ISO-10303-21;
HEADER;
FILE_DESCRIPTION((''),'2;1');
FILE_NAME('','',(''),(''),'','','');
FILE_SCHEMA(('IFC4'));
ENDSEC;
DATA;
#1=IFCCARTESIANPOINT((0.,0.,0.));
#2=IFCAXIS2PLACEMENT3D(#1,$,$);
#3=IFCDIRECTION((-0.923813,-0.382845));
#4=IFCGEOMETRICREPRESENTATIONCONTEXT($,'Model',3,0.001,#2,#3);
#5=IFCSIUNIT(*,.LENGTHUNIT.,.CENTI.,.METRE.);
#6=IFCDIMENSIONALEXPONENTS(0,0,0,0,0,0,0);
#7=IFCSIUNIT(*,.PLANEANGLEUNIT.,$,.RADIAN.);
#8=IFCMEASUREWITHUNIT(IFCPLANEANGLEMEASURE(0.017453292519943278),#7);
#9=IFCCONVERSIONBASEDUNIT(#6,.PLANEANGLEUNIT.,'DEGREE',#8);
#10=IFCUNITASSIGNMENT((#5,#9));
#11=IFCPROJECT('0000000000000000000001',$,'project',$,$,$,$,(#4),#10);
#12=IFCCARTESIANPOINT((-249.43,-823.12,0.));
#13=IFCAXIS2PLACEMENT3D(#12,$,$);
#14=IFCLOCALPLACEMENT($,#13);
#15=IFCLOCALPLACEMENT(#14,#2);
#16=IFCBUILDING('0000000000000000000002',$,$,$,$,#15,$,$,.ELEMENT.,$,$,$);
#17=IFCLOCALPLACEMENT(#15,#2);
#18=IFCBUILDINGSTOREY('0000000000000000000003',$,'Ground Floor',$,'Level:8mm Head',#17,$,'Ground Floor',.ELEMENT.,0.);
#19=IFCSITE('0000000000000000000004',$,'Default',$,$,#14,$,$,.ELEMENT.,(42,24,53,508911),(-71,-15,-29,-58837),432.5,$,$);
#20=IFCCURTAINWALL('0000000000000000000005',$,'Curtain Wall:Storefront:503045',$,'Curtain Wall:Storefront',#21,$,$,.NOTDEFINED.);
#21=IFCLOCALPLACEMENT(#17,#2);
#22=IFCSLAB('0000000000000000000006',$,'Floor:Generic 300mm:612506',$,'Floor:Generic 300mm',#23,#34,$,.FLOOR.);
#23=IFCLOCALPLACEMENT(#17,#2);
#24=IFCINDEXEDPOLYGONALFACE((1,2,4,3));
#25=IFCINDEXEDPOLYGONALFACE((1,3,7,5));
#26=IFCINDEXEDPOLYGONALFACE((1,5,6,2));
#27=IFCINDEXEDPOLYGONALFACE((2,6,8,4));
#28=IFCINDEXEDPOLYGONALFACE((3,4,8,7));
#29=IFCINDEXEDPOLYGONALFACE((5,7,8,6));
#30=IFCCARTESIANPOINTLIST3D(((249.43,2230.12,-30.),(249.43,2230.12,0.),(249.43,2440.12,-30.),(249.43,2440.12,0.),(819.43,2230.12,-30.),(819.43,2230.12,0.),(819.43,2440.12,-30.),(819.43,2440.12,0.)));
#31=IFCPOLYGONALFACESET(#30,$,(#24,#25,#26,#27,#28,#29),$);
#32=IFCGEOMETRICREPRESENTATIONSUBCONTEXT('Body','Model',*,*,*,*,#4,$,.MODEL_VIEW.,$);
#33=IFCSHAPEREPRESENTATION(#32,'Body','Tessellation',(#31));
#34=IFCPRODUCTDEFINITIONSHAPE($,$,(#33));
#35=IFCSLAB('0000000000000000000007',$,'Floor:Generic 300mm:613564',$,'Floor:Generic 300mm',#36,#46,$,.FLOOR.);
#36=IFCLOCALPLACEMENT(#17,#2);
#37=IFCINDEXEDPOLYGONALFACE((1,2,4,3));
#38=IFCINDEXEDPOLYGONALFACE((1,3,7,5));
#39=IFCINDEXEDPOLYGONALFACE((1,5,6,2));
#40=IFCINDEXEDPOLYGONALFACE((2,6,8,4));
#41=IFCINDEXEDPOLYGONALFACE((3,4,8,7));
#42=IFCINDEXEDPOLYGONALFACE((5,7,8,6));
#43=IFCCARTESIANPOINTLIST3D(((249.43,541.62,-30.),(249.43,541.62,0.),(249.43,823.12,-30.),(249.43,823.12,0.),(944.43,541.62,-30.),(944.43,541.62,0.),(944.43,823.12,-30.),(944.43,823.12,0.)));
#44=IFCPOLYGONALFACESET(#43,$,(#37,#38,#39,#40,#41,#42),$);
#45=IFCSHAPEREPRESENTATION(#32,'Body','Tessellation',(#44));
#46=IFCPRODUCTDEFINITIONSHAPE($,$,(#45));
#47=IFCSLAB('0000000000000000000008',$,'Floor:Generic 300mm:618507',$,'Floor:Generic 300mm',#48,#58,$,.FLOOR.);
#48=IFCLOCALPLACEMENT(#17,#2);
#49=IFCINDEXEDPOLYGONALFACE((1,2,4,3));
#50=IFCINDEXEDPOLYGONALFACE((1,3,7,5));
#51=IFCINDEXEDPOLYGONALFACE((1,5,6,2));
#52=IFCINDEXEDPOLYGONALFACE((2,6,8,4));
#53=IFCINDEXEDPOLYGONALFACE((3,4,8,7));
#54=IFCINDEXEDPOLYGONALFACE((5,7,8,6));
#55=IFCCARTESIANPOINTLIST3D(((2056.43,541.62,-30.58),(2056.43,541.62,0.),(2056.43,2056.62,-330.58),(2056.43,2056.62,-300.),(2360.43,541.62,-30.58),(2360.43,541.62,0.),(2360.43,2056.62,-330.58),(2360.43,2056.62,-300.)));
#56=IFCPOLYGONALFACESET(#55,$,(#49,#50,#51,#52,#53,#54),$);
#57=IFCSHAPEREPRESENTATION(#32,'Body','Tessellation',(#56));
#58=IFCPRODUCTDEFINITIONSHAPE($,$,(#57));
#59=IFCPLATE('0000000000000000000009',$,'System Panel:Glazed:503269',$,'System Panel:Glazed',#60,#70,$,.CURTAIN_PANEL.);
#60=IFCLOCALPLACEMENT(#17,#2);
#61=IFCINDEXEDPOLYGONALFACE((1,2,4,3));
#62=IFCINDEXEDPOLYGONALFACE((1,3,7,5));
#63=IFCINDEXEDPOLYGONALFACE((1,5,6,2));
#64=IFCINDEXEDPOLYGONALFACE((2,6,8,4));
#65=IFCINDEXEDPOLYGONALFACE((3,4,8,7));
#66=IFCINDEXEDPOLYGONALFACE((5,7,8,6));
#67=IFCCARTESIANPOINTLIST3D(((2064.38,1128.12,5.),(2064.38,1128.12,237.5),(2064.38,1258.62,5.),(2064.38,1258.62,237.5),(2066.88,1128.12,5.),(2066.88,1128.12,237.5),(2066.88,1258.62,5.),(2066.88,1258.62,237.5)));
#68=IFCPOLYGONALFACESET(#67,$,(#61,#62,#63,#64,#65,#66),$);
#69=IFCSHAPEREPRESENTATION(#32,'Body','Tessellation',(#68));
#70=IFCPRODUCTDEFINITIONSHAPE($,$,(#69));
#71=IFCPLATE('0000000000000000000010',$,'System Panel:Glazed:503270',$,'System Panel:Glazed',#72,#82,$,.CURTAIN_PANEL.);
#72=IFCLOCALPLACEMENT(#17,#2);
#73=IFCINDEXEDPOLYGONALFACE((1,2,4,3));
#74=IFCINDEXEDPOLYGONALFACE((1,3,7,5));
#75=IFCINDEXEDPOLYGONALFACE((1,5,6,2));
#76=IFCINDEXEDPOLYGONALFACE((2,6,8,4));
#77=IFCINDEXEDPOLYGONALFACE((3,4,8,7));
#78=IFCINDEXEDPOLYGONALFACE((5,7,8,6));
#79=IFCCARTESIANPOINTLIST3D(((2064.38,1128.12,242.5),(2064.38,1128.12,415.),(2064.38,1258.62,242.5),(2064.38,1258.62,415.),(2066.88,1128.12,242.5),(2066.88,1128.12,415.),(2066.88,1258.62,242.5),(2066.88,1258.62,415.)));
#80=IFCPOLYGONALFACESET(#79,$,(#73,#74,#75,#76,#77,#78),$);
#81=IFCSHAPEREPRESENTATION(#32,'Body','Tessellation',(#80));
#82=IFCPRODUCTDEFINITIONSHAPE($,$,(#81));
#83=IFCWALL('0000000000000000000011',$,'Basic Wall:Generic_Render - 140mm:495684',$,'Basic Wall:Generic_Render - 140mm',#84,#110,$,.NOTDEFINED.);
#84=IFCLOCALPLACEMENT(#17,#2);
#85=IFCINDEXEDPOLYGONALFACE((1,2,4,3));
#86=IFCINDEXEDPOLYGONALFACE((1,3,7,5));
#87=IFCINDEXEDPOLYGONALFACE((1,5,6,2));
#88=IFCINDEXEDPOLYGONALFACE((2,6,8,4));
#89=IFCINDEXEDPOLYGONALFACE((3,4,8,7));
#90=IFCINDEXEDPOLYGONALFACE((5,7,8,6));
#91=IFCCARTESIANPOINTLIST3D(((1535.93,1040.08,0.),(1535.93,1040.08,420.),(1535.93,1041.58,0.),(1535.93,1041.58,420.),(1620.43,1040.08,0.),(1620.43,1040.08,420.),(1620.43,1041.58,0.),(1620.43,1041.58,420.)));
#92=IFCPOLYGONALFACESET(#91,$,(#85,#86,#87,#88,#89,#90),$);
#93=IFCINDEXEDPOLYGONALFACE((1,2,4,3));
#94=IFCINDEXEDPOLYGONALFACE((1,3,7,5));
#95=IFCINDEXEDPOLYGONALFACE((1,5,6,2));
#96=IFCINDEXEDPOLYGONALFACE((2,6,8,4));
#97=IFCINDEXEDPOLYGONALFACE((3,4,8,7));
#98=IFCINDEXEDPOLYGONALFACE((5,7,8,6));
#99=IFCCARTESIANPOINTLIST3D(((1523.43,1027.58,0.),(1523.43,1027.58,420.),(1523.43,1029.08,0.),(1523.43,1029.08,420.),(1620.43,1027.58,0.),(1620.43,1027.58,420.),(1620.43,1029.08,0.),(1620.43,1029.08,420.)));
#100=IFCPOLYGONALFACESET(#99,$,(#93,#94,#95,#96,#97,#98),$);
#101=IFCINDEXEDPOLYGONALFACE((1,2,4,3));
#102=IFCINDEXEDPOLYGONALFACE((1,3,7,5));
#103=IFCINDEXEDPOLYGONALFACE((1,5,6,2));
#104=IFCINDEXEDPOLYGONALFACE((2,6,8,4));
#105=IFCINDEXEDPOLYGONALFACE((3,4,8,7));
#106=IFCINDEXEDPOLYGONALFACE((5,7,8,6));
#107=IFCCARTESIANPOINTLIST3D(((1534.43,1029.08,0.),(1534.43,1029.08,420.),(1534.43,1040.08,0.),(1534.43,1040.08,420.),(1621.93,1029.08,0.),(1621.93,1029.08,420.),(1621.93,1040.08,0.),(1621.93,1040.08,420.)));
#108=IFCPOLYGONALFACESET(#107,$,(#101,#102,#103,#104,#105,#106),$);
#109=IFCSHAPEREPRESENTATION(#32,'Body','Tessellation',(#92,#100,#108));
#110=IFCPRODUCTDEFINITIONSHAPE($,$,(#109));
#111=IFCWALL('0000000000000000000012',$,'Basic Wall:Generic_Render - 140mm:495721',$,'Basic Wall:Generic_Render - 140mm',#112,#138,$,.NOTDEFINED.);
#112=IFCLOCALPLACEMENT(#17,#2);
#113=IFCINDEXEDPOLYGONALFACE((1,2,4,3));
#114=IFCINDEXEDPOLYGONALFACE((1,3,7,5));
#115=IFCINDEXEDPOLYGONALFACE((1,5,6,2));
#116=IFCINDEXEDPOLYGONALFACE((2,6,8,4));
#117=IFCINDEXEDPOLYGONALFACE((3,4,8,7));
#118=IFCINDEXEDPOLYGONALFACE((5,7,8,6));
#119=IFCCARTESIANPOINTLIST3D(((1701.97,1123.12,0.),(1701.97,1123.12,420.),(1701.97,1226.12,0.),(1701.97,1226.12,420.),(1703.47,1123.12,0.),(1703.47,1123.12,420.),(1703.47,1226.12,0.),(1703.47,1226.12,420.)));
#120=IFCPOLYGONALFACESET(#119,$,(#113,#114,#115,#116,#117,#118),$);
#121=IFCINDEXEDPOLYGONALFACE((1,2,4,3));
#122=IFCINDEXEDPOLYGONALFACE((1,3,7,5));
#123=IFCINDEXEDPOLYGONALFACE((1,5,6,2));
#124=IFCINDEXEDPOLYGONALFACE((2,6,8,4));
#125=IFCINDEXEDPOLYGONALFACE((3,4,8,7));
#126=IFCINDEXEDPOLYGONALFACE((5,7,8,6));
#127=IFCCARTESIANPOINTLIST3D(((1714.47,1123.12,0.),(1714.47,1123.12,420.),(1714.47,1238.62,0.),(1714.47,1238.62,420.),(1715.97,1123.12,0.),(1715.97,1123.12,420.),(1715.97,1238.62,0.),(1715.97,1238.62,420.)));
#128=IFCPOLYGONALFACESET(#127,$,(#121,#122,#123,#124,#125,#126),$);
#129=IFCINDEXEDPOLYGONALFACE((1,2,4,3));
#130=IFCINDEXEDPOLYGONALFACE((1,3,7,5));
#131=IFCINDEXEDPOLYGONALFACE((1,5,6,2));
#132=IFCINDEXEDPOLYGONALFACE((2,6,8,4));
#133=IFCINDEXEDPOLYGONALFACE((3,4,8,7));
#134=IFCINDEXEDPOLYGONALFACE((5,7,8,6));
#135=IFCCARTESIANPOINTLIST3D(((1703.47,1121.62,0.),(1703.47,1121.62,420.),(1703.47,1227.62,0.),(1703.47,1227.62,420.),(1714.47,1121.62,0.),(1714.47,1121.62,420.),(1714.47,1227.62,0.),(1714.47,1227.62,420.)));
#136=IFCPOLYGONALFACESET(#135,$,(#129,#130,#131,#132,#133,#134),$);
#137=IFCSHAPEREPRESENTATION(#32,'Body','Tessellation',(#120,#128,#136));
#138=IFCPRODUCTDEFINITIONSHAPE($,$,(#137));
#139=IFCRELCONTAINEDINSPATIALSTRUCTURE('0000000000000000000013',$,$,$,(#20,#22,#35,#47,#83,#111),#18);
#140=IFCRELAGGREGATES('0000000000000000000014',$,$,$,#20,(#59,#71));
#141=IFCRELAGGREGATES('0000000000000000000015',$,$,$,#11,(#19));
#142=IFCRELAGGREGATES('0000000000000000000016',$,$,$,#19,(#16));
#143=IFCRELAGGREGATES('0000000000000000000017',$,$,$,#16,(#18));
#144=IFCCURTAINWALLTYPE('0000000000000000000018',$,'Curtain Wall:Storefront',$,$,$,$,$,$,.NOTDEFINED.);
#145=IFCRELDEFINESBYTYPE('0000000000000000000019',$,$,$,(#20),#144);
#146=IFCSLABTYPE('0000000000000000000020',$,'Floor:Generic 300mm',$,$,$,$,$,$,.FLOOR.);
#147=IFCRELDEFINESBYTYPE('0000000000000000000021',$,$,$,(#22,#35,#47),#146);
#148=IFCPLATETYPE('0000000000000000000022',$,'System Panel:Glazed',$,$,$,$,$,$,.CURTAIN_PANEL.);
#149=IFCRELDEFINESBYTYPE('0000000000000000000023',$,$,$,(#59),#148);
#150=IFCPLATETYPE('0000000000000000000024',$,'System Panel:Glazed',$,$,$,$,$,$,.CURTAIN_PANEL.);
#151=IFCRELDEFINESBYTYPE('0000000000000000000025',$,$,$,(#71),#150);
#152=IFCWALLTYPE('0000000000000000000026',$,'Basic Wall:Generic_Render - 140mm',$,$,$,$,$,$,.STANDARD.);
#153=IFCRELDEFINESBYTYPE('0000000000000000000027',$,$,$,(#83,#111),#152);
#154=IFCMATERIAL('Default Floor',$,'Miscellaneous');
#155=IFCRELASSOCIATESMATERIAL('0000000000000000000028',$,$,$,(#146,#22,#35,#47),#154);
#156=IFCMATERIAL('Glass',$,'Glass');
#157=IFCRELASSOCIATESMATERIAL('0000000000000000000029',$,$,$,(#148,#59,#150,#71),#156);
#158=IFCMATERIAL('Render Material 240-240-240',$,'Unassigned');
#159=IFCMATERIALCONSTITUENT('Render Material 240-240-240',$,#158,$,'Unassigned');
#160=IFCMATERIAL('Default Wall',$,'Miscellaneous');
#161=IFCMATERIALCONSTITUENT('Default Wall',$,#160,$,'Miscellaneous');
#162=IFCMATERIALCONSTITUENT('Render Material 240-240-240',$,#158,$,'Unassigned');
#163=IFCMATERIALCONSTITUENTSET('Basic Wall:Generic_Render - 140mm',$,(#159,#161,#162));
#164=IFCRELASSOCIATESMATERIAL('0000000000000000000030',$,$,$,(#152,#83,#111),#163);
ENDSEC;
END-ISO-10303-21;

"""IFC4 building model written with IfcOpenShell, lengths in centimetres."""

from ifc_helpers import new_model, entity, si_unit, converted_unit, direction, frame, frame_2d, origin, place, context, subcontext, project, spatial, indexed_curve, rectangle, outline, extrude, source, transform, mapped, material, constituent, constituent_set, type_object, type_shapes, element, aggregate, save


model = new_model("IFC4")

# Units and contexts
model_context = context("Model", 3, precision=0.001, world=origin(), true_north=direction((-0.923813, -0.382845)))
body_context = subcontext(model_context, "Body", "Model", "MODEL_VIEW")
ifc_project = project(units=[si_unit("LENGTHUNIT", "METRE", prefix="CENTI"), converted_unit("PLANEANGLEUNIT", "DEGREE", entity("IfcPlaneAngleMeasure", 0.017453292519943278), si_unit("PLANEANGLEUNIT", "RADIAN"), dimensions=[0, 0, 0, 0, 0, 0, 0])], contexts=[model_context])

# Site, building, storey
site_placement = place(None, frame((-249.43, -823.12, 0.0)))
site = spatial("IfcSite", under=ifc_project, at=site_placement, Name="Default", CompositionType="ELEMENT", RefLatitude=(42, 24, 53, 508911), RefLongitude=(-71, -15, -29, -58837), RefElevation=432.5)
building_placement = place(site_placement, origin())
building = spatial("IfcBuilding", under=site, at=building_placement, CompositionType="ELEMENT")
storey_placement = place(building_placement, origin())
storey = spatial("IfcBuildingStorey", under=building, at=storey_placement, Name="Ground Floor", ObjectType="Level:8mm Head", LongName="Ground Floor", CompositionType="ELEMENT", Elevation=0.0)

# Curtain wall
curtain_wall_type = type_object("IfcCurtainWallType", Name="Curtain Wall:Storefront", PredefinedType="NOTDEFINED")
curtain_wall_placement = place(storey_placement, origin())
curtain_wall = element("IfcCurtainWall", 1, at=curtain_wall_placement, inside=storey, type_object=curtain_wall_type, Name="Curtain Wall:Storefront:503045", ObjectType="Curtain Wall:Storefront", PredefinedType="NOTDEFINED")

# Slabs
ifc_material_1 = material(Name="Default Floor", Category="Miscellaneous")
slab_type = type_object("IfcSlabType", Name="Floor:Generic 300mm", PredefinedType="FLOOR", material=ifc_material_1)
slab_1_placement = place(storey_placement, origin())
element("IfcSlab", 2, at=slab_1_placement, inside=storey, type_object=slab_type, material=ifc_material_1, Name="Floor:Generic 300mm:612506", ObjectType="Floor:Generic 300mm", PredefinedType="FLOOR", context=body_context, shape_type="SweptSolid", body=[
    extrude(outline(indexed_curve([(-105.0, -285.0), (105.0, -285.0), (105.0, 285.0), (-105.0, 285.0), (-105.0, -285.0)], self_intersect=False)), frame((534.43, 2335.12, 0.0), z_axis=(0.0, 0.0, -1.0), x_axis=(0.0, 1.0, 0.0)), (0.0, 0.0, 1.0), 30.0),
])
slab_2_placement = place(storey_placement, origin())
element("IfcSlab", 3, at=slab_2_placement, inside=storey, type_object=slab_type, material=ifc_material_1, Name="Floor:Generic 300mm:613564", ObjectType="Floor:Generic 300mm", PredefinedType="FLOOR", context=body_context, shape_type="SweptSolid", body=[
    extrude(outline(indexed_curve([(-140.75, -347.5), (140.75, -347.5), (140.75, 347.5), (-140.75, 347.5), (-140.75, -347.5)], self_intersect=False)), frame((596.93, 682.37, 0.0), z_axis=(0.0, 0.0, -1.0), x_axis=(0.0, 1.0, 0.0)), (0.0, 0.0, 1.0), 30.0),
])
slab_3_placement = place(storey_placement, frame((2056.43, 541.62, -330.58)))
element("IfcSlab", 4, at=slab_3_placement, inside=storey, type_object=slab_type, material=ifc_material_1, Name="Floor:Generic 300mm:618507", ObjectType="Floor:Generic 300mm", PredefinedType="FLOOR", context=body_context, shape_type="SweptSolid", body=[
    extrude(rectangle(XDim=1544.42, YDim=304.0, at=frame_2d((-7.0, -772.21), x_axis=(0.0, 1.0))), frame((159.0, 1515.0, 30.58), z_axis=(0.0, 0.194248, 0.980952), x_axis=(1.0, 0.0, 0.0)), (0.0, 0.194248, -0.980952), 30.58),
])

# Plates
ifc_material_2 = material(Name="Glass", Category="Glass")
plate_type_1 = type_object("IfcPlateType", Name="System Panel:Glazed", PredefinedType="CURTAIN_PANEL", material=ifc_material_2)
shared_shape_1 = source(origin(), body_context, "Body", "SweptSolid", [
    extrude(outline(indexed_curve([(-1.25, -65.25), (1.25, -65.25), (1.25, 65.25), (-1.25, 65.25), (-1.25, -65.25)], self_intersect=False)), frame((0.0, 3.7, 0.0), z_axis=(0.0, 0.0, 1.0), x_axis=(0.0, 1.0, 0.0)), (0.0, 0.0, 1.0), 232.5),
])
type_shapes(plate_type_1, [shared_shape_1])
plate_1_placement = place(curtain_wall_placement, frame((2061.93, 1193.37, 5.0), z_axis=(0.0, 0.0, 1.0), x_axis=(0.0, -1.0, 0.0)))
plate_1 = element("IfcPlate", 5, at=plate_1_placement, type_object=plate_type_1, material=ifc_material_2, Name="System Panel:Glazed:503269", ObjectType="System Panel:Glazed", PredefinedType="CURTAIN_PANEL", context=body_context, shape_type="MappedRepresentation", body=[
    mapped(shared_shape_1, transform((0.0, 0.0, 0.0), scale=1.0)),
])
plate_type_2 = type_object("IfcPlateType", Name="System Panel:Glazed", PredefinedType="CURTAIN_PANEL", material=ifc_material_2)
shared_shape_2 = source(origin(), body_context, "Body", "SweptSolid", [
    extrude(outline(indexed_curve([(-1.25, -65.25), (1.25, -65.25), (1.25, 65.25), (-1.25, 65.25), (-1.25, -65.25)], self_intersect=False)), frame((0.0, 3.7, 0.0), z_axis=(0.0, 0.0, 1.0), x_axis=(0.0, 1.0, 0.0)), (0.0, 0.0, 1.0), 172.5),
])
type_shapes(plate_type_2, [shared_shape_2])
plate_2_placement = place(curtain_wall_placement, frame((2061.93, 1193.37, 242.5), z_axis=(0.0, 0.0, 1.0), x_axis=(0.0, -1.0, 0.0)))
plate_2 = element("IfcPlate", 6, at=plate_2_placement, type_object=plate_type_2, material=ifc_material_2, Name="System Panel:Glazed:503270", ObjectType="System Panel:Glazed", PredefinedType="CURTAIN_PANEL", context=body_context, shape_type="MappedRepresentation", body=[
    mapped(shared_shape_2, transform((0.0, 0.0, 0.0), scale=1.0)),
])
aggregate(curtain_wall, [plate_1, plate_2])

# Walls
ifc_material_3 = material(Name="Render Material 240-240-240", Category="Unassigned")
ifc_material_4 = material(Name="Default Wall", Category="Miscellaneous")
ifc_constituent_1 = constituent(ifc_material_3, Name="Render Material 240-240-240", Category="Unassigned")
ifc_constituent_2 = constituent(ifc_material_4, Name="Default Wall", Category="Miscellaneous")
ifc_constituent_3 = constituent(ifc_material_3, Name="Render Material 240-240-240", Category="Unassigned")
ifc_constituent_set_1 = constituent_set(constituents=[ifc_constituent_1, ifc_constituent_2, ifc_constituent_3], Name="Basic Wall:Generic_Render - 140mm")
wall_type_1 = type_object("IfcWallType", Name="Basic Wall:Generic_Render - 140mm", PredefinedType="STANDARD", material=ifc_constituent_set_1)
wall_1_placement = place(storey_placement, frame((1535.93, 1034.58, 0.0)))
element("IfcWall", 7, at=wall_1_placement, inside=storey, type_object=wall_type_1, material=ifc_constituent_set_1, Name="Basic Wall:Generic_Render - 140mm:495684", ObjectType="Basic Wall:Generic_Render - 140mm", PredefinedType="NOTDEFINED", context=body_context, shape_type="SweptSolid", body=[
    extrude(outline(indexed_curve([(-0.75, -42.25), (0.75, -42.25), (0.75, 42.25), (-0.75, 42.25), (-0.75, -42.25)], self_intersect=False)), frame((42.25, 6.25, 0.0), z_axis=(0.0, 0.0, 1.0), x_axis=(0.0, -1.0, 0.0)), (0.0, 0.0, 1.0), 420.0),
    extrude(outline(indexed_curve([(-0.75, -48.5), (0.75, -48.5), (0.75, 48.5), (-0.75, 48.5), (-0.75, -48.5)], self_intersect=False)), frame((36.0, -6.25, 0.0), z_axis=(0.0, 0.0, 1.0), x_axis=(0.0, 1.0, 0.0)), (0.0, 0.0, 1.0), 420.0),
    extrude(outline(indexed_curve([(-43.75, -5.5), (43.75, -5.5), (43.75, 5.5), (-43.75, 5.5), (-43.75, -5.5)], self_intersect=False)), frame((42.25, 0.0, 0.0)), (0.0, 0.0, 1.0), 420.0),
])
wall_2_placement = place(storey_placement, frame((1708.97, 1226.12, 0.0), z_axis=(0.0, 0.0, 1.0), x_axis=(0.0, -1.0, 0.0)))
element("IfcWall", 8, at=wall_2_placement, inside=storey, type_object=wall_type_1, material=ifc_constituent_set_1, Name="Basic Wall:Generic_Render - 140mm:495721", ObjectType="Basic Wall:Generic_Render - 140mm", PredefinedType="NOTDEFINED", context=body_context, shape_type="SweptSolid", body=[
    extrude(outline(indexed_curve([(-0.75, -51.5), (0.75, -51.5), (0.75, 51.5), (-0.75, 51.5), (-0.75, -51.5)], self_intersect=False)), frame((51.5, -6.25, 0.0), z_axis=(0.0, 0.0, 1.0), x_axis=(0.0, 1.0, 0.0)), (0.0, 0.0, 1.0), 420.0),
    extrude(outline(indexed_curve([(-0.75, -57.75), (0.75, -57.75), (0.75, 57.75), (-0.75, 57.75), (-0.75, -57.75)], self_intersect=False)), frame((45.25, 6.25, 0.0), z_axis=(0.0, 0.0, 1.0), x_axis=(0.0, -1.0, 0.0)), (0.0, 0.0, 1.0), 420.0),
    extrude(outline(indexed_curve([(-53.0, -5.5), (53.0, -5.5), (53.0, 5.5), (-53.0, 5.5), (-53.0, -5.5)], self_intersect=False)), frame((51.5, 0.0, 0.0)), (0.0, 0.0, 1.0), 420.0),
])

save(model, "model.ifc")
